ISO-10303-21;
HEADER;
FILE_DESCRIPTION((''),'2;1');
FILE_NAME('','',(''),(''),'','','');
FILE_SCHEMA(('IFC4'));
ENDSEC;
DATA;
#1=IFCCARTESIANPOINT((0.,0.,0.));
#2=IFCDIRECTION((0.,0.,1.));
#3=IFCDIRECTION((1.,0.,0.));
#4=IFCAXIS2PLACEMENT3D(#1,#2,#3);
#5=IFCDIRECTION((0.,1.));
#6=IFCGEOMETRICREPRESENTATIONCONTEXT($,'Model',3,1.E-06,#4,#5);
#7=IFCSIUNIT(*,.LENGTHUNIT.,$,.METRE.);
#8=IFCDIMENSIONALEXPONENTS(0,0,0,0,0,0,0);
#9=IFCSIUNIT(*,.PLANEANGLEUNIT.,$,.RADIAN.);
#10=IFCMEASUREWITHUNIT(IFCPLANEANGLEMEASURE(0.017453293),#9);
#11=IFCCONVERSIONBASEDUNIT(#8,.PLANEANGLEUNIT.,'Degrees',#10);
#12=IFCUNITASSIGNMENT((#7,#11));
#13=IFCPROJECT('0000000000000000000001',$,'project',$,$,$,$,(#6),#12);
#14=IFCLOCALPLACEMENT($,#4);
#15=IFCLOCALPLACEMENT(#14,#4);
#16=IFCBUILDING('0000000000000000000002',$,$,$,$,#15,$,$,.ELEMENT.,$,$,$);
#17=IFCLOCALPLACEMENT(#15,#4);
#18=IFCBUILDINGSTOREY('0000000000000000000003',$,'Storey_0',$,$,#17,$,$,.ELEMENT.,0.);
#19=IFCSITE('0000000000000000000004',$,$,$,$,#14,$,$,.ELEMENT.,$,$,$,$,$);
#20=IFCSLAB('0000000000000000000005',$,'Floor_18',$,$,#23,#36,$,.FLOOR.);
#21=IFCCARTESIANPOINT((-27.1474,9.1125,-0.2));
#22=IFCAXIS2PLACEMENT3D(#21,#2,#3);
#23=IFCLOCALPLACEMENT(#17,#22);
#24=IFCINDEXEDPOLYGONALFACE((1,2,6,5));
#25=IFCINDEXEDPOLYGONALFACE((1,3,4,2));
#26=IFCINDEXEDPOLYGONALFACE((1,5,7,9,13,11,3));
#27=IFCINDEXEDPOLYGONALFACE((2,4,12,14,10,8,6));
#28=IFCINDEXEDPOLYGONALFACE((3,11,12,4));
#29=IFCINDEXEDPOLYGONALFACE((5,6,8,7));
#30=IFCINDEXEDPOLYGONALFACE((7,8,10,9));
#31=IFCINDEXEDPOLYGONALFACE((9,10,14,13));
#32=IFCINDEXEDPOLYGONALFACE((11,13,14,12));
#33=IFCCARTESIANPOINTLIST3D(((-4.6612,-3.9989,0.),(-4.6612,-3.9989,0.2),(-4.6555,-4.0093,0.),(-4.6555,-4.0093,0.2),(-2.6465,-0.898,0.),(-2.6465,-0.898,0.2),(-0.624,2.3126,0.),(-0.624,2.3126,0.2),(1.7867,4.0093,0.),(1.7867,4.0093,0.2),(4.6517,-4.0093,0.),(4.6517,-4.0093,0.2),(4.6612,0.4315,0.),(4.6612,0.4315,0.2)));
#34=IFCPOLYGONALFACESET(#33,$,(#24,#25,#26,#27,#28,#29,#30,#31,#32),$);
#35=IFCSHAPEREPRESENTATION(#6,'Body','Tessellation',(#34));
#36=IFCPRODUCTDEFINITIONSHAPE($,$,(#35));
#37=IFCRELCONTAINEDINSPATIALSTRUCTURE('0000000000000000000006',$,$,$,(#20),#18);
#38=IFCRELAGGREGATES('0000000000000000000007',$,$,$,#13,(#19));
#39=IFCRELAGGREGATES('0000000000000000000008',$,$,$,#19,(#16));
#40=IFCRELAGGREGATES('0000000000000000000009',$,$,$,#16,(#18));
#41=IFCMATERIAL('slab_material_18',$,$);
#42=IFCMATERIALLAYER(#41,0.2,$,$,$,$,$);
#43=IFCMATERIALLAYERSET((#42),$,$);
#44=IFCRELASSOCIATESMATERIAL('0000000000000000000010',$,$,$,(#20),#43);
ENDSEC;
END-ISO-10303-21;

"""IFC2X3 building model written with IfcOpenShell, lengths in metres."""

from ifc_helpers import new_model, entity, si_unit, converted_unit, direction, frame, origin_with_axes, place, context, project, spatial, polyline, outline, extrude, material, layer, layer_set, layer_usage, element, save


model = new_model("IFC2X3")

# Units and contexts
model_context = context("Model", 3, precision=1e-06, world=origin_with_axes(), true_north=direction((0.0, 1.0)))
ifc_project = project(units=[si_unit("LENGTHUNIT", "METRE"), converted_unit("PLANEANGLEUNIT", "Degrees", entity("IfcPlaneAngleMeasure", 0.017453293), si_unit("PLANEANGLEUNIT", "RADIAN"), dimensions=[0, 0, 0, 0, 0, 0, 0])], contexts=[model_context])

# Site, building, storey
site_placement = place(None, origin_with_axes())
site = spatial("IfcSite", under=ifc_project, at=site_placement, CompositionType="ELEMENT")
building_placement = place(site_placement, origin_with_axes())
building = spatial("IfcBuilding", under=site, at=building_placement, CompositionType="ELEMENT")
storey_placement = place(building_placement, origin_with_axes())
storey = spatial("IfcBuildingStorey", under=building, at=storey_placement, Name="Storey_0", CompositionType="ELEMENT", Elevation=0.0)

# Slab
ifc_material_1 = material(Name="slab_material_18")
ifc_layer_1 = layer(ifc_material_1, 0.2)
ifc_layer_set_1 = layer_set([ifc_layer_1])
ifc_layer_usage_1 = layer_usage(ifc_layer_set_1, "AXIS3", "POSITIVE", 0.0)
slab_placement = place(storey_placement, frame((-27.1474, 9.1125, -0.2), z_axis=(0.0, 0.0, 1.0), x_axis=(1.0, 0.0, 0.0)))
element("IfcSlab", 1, at=slab_placement, inside=storey, material=ifc_layer_usage_1, Name="Floor_18", PredefinedType="FLOOR", context=model_context, shape_type="SweptSolid", body=[
    extrude(outline(polyline([(4.6612, 0.4315), (4.6517, -4.0093), (-4.6555, -4.0093), (-4.6612, -3.9989), (-2.6465, -0.898), (-0.624, 2.3126), (1.7867, 4.0093), (4.6612, 0.4315)])), origin_with_axes(), (0.0, 0.0, 1.0), 0.2),
])

save(model, "model.ifc")
